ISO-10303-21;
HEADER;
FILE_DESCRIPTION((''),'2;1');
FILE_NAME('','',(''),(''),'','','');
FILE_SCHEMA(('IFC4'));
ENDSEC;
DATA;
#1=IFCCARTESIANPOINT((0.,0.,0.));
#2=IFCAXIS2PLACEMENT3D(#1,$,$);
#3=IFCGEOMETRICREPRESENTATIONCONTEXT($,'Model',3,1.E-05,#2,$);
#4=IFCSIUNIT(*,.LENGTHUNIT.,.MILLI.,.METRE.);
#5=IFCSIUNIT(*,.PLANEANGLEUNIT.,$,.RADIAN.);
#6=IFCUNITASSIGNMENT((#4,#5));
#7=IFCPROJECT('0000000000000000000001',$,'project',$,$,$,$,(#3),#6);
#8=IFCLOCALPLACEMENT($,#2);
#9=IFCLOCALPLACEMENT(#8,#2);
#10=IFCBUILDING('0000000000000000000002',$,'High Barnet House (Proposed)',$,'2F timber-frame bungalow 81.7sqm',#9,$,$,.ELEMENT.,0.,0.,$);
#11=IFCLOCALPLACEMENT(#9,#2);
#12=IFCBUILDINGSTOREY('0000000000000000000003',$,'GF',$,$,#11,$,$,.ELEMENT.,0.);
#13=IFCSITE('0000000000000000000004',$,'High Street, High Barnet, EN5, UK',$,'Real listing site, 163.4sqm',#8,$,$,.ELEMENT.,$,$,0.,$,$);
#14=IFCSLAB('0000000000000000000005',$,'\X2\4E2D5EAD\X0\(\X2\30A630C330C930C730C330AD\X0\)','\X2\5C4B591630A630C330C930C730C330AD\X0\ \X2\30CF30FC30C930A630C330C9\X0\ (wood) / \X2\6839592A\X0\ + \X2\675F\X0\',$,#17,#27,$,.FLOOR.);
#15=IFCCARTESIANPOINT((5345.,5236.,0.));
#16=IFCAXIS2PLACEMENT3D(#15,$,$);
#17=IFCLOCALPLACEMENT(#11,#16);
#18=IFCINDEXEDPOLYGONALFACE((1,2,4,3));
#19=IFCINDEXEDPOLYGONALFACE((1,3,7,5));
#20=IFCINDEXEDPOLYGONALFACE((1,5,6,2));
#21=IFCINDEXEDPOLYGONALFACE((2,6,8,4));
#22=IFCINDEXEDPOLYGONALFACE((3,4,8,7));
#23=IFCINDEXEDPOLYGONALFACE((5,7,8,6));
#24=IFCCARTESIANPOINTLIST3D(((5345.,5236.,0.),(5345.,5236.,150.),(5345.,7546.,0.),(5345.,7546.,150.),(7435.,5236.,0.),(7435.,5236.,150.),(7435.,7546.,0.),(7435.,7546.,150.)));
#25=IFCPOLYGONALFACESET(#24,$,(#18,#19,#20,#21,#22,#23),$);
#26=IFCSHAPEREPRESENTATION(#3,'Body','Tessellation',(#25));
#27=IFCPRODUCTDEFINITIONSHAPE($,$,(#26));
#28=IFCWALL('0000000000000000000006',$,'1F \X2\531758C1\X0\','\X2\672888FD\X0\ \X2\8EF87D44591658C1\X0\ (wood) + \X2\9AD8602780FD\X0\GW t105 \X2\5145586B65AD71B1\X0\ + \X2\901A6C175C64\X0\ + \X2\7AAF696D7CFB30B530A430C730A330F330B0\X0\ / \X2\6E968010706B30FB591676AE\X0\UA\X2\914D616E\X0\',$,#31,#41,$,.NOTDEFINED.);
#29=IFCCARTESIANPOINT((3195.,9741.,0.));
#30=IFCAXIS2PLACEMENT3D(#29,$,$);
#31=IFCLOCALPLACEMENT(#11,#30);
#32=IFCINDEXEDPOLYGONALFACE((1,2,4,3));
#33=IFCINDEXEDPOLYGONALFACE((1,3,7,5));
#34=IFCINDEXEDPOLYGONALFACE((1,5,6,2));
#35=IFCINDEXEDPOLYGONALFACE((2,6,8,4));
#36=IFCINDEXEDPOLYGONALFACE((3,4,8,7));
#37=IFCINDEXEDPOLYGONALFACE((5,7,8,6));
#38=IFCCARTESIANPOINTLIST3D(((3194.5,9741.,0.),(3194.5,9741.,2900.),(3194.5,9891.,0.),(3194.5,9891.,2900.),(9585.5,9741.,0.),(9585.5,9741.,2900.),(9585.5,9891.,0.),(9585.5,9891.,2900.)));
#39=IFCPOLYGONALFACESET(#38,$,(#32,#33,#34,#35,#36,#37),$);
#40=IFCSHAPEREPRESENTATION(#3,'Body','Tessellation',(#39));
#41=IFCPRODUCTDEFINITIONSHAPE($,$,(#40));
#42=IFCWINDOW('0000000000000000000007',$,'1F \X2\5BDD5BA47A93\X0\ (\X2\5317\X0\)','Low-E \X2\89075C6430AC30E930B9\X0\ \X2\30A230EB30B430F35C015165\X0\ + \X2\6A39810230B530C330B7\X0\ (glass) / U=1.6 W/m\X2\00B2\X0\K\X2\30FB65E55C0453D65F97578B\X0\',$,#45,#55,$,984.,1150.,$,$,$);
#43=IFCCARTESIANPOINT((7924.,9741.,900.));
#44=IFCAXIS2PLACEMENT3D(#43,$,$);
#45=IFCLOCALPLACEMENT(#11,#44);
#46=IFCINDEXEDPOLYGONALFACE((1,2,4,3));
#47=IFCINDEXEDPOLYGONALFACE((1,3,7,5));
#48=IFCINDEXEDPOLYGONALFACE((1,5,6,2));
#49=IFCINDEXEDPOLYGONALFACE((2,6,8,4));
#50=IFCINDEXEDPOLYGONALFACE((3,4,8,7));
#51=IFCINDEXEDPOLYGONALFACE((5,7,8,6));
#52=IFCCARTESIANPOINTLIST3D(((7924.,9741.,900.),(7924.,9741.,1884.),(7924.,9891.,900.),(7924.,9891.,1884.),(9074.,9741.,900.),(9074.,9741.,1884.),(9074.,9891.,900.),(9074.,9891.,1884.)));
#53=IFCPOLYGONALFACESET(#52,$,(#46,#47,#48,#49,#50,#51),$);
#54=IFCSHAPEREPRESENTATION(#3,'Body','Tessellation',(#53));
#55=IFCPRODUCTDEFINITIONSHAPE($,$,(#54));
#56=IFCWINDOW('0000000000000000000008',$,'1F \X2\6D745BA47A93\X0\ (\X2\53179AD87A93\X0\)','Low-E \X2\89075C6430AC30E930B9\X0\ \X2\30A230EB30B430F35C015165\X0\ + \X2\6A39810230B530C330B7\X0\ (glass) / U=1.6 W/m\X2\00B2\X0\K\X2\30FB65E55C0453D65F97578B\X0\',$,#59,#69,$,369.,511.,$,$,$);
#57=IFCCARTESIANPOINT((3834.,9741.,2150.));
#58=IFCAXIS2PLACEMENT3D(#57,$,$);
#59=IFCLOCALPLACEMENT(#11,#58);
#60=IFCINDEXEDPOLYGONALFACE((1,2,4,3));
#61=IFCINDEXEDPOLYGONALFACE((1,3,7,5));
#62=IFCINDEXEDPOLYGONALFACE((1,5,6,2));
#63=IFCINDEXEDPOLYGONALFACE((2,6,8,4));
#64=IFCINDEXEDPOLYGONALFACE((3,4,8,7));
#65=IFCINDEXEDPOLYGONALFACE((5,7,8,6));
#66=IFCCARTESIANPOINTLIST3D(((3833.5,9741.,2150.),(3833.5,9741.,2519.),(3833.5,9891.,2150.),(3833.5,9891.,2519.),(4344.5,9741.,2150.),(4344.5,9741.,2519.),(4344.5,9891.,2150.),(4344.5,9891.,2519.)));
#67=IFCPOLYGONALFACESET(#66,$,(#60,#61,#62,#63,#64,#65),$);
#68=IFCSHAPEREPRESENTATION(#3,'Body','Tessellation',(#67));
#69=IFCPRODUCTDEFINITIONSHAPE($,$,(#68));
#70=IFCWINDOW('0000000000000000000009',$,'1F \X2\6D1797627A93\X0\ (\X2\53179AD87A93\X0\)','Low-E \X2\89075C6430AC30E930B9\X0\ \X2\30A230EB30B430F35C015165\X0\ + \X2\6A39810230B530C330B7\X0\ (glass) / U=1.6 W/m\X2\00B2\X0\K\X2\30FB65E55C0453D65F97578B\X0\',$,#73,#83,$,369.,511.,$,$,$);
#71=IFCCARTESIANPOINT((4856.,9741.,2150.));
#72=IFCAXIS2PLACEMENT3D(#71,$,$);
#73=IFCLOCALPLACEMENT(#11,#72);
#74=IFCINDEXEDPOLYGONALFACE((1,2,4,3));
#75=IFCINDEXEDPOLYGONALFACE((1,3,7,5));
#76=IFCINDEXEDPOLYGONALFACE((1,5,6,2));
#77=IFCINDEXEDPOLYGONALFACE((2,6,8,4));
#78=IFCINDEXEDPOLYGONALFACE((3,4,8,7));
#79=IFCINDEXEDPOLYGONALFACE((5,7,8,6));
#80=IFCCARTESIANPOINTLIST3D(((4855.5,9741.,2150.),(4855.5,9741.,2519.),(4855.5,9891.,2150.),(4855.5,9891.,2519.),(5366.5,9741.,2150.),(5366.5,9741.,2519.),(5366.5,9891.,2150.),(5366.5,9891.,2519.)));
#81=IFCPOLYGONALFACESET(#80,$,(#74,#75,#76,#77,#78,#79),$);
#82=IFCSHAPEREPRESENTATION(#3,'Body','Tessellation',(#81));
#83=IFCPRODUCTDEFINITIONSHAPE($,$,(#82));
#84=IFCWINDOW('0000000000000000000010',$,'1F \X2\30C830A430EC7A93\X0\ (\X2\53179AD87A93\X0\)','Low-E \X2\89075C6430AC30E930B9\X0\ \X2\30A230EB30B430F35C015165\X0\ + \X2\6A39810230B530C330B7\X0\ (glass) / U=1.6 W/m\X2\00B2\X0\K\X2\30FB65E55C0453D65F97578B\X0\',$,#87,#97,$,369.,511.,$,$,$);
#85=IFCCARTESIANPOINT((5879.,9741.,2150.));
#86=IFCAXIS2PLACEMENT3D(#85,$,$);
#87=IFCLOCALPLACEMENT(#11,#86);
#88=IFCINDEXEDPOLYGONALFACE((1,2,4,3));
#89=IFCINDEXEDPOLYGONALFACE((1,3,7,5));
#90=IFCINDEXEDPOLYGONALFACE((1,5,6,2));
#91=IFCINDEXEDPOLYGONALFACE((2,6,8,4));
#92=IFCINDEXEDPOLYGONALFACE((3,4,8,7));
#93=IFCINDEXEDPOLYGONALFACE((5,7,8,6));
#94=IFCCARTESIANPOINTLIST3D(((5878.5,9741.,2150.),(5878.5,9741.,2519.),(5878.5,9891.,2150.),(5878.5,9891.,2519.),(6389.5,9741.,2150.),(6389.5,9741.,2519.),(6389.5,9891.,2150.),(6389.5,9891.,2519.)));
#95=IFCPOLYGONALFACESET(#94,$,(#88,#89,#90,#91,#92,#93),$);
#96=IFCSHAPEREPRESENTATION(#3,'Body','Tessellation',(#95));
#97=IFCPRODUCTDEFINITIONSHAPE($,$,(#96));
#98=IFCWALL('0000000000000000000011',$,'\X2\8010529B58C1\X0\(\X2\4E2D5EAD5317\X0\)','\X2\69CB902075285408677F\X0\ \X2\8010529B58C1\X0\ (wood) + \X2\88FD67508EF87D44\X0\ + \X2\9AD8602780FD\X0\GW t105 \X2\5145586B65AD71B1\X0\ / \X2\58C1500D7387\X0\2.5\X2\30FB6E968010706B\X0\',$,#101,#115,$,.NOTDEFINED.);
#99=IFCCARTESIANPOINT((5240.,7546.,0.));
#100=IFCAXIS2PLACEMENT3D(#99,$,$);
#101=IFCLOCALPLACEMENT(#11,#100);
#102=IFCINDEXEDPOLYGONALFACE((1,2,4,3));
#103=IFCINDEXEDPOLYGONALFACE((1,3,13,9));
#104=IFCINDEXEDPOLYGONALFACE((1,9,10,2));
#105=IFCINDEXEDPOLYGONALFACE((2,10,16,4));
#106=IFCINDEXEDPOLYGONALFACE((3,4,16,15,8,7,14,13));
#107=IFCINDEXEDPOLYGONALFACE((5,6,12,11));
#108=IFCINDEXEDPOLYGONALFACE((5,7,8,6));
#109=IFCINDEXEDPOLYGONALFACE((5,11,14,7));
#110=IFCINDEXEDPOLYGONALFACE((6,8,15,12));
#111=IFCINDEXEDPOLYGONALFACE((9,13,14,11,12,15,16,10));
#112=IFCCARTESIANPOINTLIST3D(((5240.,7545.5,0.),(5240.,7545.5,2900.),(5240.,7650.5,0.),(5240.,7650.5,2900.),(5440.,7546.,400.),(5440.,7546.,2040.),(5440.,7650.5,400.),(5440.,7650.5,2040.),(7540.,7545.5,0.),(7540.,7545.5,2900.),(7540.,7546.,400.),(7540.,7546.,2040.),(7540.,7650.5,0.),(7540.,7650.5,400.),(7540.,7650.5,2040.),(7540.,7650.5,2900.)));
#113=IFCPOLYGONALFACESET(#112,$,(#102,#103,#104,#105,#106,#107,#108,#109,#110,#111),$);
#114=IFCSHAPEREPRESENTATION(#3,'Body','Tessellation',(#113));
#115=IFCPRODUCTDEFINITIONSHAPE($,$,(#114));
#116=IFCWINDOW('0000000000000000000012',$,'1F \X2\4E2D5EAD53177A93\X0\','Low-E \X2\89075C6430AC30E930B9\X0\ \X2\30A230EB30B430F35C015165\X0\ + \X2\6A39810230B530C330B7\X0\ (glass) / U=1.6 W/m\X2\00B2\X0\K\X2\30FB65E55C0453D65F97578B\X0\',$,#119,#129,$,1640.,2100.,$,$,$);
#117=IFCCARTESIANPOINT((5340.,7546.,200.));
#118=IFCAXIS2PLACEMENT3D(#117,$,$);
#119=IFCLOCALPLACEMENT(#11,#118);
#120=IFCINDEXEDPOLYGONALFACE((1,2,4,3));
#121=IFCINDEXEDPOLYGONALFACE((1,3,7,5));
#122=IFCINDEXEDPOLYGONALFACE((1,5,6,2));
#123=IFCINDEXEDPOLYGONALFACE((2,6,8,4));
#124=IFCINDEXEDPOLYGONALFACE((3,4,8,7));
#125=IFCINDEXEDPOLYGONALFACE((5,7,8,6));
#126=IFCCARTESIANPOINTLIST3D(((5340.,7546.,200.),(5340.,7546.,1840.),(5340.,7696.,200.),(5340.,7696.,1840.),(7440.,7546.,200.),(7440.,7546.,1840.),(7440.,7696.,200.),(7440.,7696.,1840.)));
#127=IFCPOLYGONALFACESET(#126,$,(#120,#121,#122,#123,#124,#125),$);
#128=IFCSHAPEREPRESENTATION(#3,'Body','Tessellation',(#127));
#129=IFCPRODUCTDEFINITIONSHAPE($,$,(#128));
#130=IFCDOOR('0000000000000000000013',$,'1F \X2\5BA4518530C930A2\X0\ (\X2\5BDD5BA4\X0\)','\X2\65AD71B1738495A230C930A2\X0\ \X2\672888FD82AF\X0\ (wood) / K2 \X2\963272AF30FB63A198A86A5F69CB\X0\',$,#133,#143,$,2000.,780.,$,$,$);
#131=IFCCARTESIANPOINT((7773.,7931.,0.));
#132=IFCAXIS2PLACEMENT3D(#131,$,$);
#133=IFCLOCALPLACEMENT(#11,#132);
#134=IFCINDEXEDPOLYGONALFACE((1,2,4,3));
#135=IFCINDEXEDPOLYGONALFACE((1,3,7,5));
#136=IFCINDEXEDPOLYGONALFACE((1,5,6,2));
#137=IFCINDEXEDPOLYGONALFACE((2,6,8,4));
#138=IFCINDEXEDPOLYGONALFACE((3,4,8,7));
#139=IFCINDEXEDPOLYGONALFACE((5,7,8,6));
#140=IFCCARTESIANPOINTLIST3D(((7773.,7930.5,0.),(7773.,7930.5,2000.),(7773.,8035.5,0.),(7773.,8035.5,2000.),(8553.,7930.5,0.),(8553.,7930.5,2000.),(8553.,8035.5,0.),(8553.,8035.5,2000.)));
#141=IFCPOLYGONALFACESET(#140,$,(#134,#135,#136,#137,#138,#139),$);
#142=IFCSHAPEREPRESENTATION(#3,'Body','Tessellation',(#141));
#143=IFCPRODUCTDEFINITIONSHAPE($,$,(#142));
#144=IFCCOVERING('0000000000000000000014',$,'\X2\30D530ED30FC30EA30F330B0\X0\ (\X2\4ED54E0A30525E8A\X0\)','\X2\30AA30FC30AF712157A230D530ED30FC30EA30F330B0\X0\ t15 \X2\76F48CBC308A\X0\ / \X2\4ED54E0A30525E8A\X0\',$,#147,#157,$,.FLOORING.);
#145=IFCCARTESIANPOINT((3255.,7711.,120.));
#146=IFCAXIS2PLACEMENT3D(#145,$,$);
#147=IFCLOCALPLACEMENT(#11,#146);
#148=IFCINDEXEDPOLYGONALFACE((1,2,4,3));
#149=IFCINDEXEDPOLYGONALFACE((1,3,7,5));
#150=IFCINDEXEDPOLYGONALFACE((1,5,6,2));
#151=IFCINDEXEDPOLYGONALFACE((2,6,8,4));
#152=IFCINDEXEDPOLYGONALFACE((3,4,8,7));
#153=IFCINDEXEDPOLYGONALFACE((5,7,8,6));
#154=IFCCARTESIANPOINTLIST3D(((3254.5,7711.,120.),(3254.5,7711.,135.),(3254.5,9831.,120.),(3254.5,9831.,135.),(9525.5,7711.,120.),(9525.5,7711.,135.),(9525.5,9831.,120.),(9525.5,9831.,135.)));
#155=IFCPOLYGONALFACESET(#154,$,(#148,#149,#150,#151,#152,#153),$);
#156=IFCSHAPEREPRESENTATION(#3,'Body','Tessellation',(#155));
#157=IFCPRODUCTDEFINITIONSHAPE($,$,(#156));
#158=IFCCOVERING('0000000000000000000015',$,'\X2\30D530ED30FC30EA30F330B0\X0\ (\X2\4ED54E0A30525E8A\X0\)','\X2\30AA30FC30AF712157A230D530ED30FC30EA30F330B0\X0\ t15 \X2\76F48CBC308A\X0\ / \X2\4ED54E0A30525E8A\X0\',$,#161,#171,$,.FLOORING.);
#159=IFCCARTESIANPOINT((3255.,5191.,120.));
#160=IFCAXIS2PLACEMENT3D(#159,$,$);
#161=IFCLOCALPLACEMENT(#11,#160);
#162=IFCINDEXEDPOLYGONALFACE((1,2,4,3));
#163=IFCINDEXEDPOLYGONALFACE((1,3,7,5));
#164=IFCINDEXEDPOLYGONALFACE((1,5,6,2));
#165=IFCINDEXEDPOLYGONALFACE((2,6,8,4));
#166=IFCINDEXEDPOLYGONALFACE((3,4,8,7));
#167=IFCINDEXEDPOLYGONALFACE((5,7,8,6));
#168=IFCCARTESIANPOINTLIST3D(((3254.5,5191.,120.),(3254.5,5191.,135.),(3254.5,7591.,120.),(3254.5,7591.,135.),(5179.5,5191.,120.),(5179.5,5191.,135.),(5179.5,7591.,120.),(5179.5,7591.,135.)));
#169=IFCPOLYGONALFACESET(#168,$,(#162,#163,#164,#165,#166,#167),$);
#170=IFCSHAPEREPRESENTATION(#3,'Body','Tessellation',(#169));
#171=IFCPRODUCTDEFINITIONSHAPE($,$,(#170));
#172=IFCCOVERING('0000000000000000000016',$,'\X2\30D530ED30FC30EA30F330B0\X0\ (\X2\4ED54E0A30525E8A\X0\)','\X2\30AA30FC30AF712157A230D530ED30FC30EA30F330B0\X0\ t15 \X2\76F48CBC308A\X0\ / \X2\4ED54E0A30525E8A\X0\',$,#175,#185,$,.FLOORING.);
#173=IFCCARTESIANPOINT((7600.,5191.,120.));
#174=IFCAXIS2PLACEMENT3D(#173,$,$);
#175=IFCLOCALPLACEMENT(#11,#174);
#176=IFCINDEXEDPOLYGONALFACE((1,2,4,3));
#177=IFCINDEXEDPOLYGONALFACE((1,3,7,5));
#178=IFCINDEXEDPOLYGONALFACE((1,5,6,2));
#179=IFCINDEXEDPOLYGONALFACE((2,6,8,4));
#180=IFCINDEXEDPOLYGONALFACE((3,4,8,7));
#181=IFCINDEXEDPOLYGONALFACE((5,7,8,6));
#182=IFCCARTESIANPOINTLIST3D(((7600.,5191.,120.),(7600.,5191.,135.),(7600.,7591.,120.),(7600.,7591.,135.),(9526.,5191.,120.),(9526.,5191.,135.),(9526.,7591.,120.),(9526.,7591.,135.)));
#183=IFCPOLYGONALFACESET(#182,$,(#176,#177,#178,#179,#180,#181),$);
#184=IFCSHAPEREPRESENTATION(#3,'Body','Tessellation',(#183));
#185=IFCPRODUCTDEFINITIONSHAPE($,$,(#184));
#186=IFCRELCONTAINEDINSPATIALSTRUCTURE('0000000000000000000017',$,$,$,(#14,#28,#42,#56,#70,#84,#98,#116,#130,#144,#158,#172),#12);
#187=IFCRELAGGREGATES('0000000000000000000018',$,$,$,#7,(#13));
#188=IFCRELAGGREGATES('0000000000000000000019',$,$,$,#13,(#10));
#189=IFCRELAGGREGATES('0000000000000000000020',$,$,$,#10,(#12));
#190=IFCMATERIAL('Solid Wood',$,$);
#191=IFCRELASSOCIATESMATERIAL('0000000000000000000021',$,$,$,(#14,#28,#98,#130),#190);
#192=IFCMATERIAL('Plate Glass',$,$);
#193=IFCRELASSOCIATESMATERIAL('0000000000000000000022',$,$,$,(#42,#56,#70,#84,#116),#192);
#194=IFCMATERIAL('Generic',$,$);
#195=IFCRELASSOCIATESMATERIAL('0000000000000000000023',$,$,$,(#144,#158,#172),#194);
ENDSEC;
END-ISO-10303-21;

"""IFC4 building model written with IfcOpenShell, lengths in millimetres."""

from ifc_helpers import new_model, si_unit, frame, frame_2d, origin, place, context, project, spatial, rectangle, extrude, material, element, fill, save


model = new_model("IFC4")

# Units and contexts
model_context = context("Model", 3, precision=1e-05, world=origin())
ifc_project = project(units=[si_unit("LENGTHUNIT", "METRE", prefix="MILLI"), si_unit("PLANEANGLEUNIT", "RADIAN")], contexts=[model_context])

# Site, building, storey
site_placement = place(None, origin())
site = spatial("IfcSite", under=ifc_project, at=site_placement, Name="High Street, High Barnet, EN5, UK", ObjectType="Real listing site, 163.4sqm", CompositionType="ELEMENT", RefElevation=0.0)
building_placement = place(site_placement, origin())
building = spatial("IfcBuilding", under=site, at=building_placement, Name="High Barnet House (Proposed)", ObjectType="2F timber-frame bungalow 81.7sqm", CompositionType="ELEMENT", ElevationOfRefHeight=0.0, ElevationOfTerrain=0.0)
storey_placement = place(building_placement, origin())
storey = spatial("IfcBuildingStorey", under=building, at=storey_placement, Name="GF", CompositionType="ELEMENT", Elevation=0.0)

# Slab
ifc_material_1 = material(Name="Solid Wood")
slab_1_placement = place(storey_placement, frame((5345.0, 5236.0, 0.0)))
element("IfcSlab", 1, at=slab_1_placement, inside=storey, material=ifc_material_1, Name="中庭(ウッドデッキ)", Description="屋外ウッドデッキ ハードウッド (wood) / 根太 + 束", PredefinedType="FLOOR", context=model_context, shape_type="SweptSolid", body=[
    extrude(rectangle(XDim=2090.0, YDim=2310.0, at=frame_2d((1045.0, 1155.0))), frame((5345.0, 5236.0, 0.0)), (0.0, 0.0, 1.0), 150.0),
])

# Wall, openings, windows
wall_1_placement = place(storey_placement, frame((3195.0, 9741.0, 0.0)))
wall_1 = element("IfcWall", 2, at=wall_1_placement, inside=storey, material=ifc_material_1, Name="1F 北壁", Description="木製 軸組外壁 (wood) + 高性能GW t105 充填断熱 + 通気層 + 窯業系サイディング / 準耐火・外皮UA配慮", PredefinedType="NOTDEFINED", context=model_context, shape_type="SweptSolid", body=[
    extrude(rectangle(XDim=6391.0, YDim=150.0, at=frame_2d((3195.0, 75.0))), frame((3195.0, 9741.0, 0.0)), (0.0, 0.0, 1.0), 2900.0),
])
opening_1_placement = place(storey_placement, frame((7924.0, 9741.0, 900.0)))
opening_1 = element("IfcOpeningElement", 3, at=opening_1_placement, cuts=wall_1, PredefinedType="NOTDEFINED", context=model_context, shape_type="SweptSolid", body=[
    extrude(rectangle(XDim=1150.0, YDim=150.0, at=frame_2d((575.0, 75.0))), frame((7924.0, 9741.0, 900.0)), (0.0, 0.0, 1.0), 984.0),
])
opening_2_placement = place(storey_placement, frame((3834.0, 9741.0, 2150.0)))
opening_2 = element("IfcOpeningElement", 4, at=opening_2_placement, cuts=wall_1, PredefinedType="NOTDEFINED", context=model_context, shape_type="SweptSolid", body=[
    extrude(rectangle(XDim=511.0, YDim=150.0, at=frame_2d((255.0, 75.0))), frame((3834.0, 9741.0, 2150.0)), (0.0, 0.0, 1.0), 369.0),
])
opening_3_placement = place(storey_placement, frame((4856.0, 9741.0, 2150.0)))
opening_3 = element("IfcOpeningElement", 5, at=opening_3_placement, cuts=wall_1, PredefinedType="NOTDEFINED", context=model_context, shape_type="SweptSolid", body=[
    extrude(rectangle(XDim=511.0, YDim=150.0, at=frame_2d((255.0, 75.0))), frame((4856.0, 9741.0, 2150.0)), (0.0, 0.0, 1.0), 369.0),
])
opening_4_placement = place(storey_placement, frame((5879.0, 9741.0, 2150.0)))
opening_4 = element("IfcOpeningElement", 6, at=opening_4_placement, cuts=wall_1, PredefinedType="NOTDEFINED", context=model_context, shape_type="SweptSolid", body=[
    extrude(rectangle(XDim=511.0, YDim=150.0, at=frame_2d((255.0, 75.0))), frame((5879.0, 9741.0, 2150.0)), (0.0, 0.0, 1.0), 369.0),
])
ifc_material_2 = material(Name="Plate Glass")
window_1_placement = place(storey_placement, frame((7924.0, 9741.0, 900.0)))
window_1 = element("IfcWindow", 7, at=window_1_placement, inside=storey, material=ifc_material_2, Name="1F 寝室窓 (北)", Description="Low-E 複層ガラス アルゴン封入 + 樹脂サッシ (glass) / U=1.6 W/m²K・日射取得型", OverallHeight=984.0, OverallWidth=1150.0, context=model_context, shape_type="SweptSolid", body=[
    extrude(rectangle(XDim=1150.0, YDim=150.0, at=frame_2d((575.0, 75.0))), frame((7924.0, 9741.0, 900.0)), (0.0, 0.0, 1.0), 984.0),
])
fill(opening_1, window_1)
window_2_placement = place(storey_placement, frame((3834.0, 9741.0, 2150.0)))
window_2 = element("IfcWindow", 8, at=window_2_placement, inside=storey, material=ifc_material_2, Name="1F 浴室窓 (北高窓)", Description="Low-E 複層ガラス アルゴン封入 + 樹脂サッシ (glass) / U=1.6 W/m²K・日射取得型", OverallHeight=369.0, OverallWidth=511.0, context=model_context, shape_type="SweptSolid", body=[
    extrude(rectangle(XDim=511.0, YDim=150.0, at=frame_2d((255.0, 75.0))), frame((3834.0, 9741.0, 2150.0)), (0.0, 0.0, 1.0), 369.0),
])
fill(opening_2, window_2)
window_3_placement = place(storey_placement, frame((4856.0, 9741.0, 2150.0)))
window_3 = element("IfcWindow", 9, at=window_3_placement, inside=storey, material=ifc_material_2, Name="1F 洗面窓 (北高窓)", Description="Low-E 複層ガラス アルゴン封入 + 樹脂サッシ (glass) / U=1.6 W/m²K・日射取得型", OverallHeight=369.0, OverallWidth=511.0, context=model_context, shape_type="SweptSolid", body=[
    extrude(rectangle(XDim=511.0, YDim=150.0, at=frame_2d((255.0, 75.0))), frame((4856.0, 9741.0, 2150.0)), (0.0, 0.0, 1.0), 369.0),
])
fill(opening_3, window_3)
window_4_placement = place(storey_placement, frame((5879.0, 9741.0, 2150.0)))
window_4 = element("IfcWindow", 10, at=window_4_placement, inside=storey, material=ifc_material_2, Name="1F トイレ窓 (北高窓)", Description="Low-E 複層ガラス アルゴン封入 + 樹脂サッシ (glass) / U=1.6 W/m²K・日射取得型", OverallHeight=369.0, OverallWidth=511.0, context=model_context, shape_type="SweptSolid", body=[
    extrude(rectangle(XDim=511.0, YDim=150.0, at=frame_2d((255.0, 75.0))), frame((5879.0, 9741.0, 2150.0)), (0.0, 0.0, 1.0), 369.0),
])
fill(opening_4, window_4)

# Wall, opening, window
wall_2_placement = place(storey_placement, frame((5240.0, 7546.0, 0.0)))
wall_2 = element("IfcWall", 11, at=wall_2_placement, inside=storey, material=ifc_material_1, Name="耐力壁(中庭北)", Description="構造用合板 耐力壁 (wood) + 製材軸組 + 高性能GW t105 充填断熱 / 壁倍率2.5・準耐火", PredefinedType="NOTDEFINED", context=model_context, shape_type="SweptSolid", body=[
    extrude(rectangle(XDim=2300.0, YDim=105.0, at=frame_2d((1150.0, 52.0))), frame((5240.0, 7546.0, 0.0)), (0.0, 0.0, 1.0), 2900.0),
])
opening_5_placement = place(storey_placement, frame((5340.0, 7546.0, 200.0)))
opening_5 = element("IfcOpeningElement", 12, at=opening_5_placement, cuts=wall_2, PredefinedType="NOTDEFINED", context=model_context, shape_type="SweptSolid", body=[
    extrude(rectangle(XDim=2100.0, YDim=150.0, at=frame_2d((1050.0, 75.0))), frame((5340.0, 7546.0, 200.0)), (0.0, 0.0, 1.0), 1640.0),
])
window_5_placement = place(storey_placement, frame((5340.0, 7546.0, 200.0)))
window_5 = element("IfcWindow", 13, at=window_5_placement, inside=storey, material=ifc_material_2, Name="1F 中庭北窓", Description="Low-E 複層ガラス アルゴン封入 + 樹脂サッシ (glass) / U=1.6 W/m²K・日射取得型", OverallHeight=1640.0, OverallWidth=2100.0, context=model_context, shape_type="SweptSolid", body=[
    extrude(rectangle(XDim=2100.0, YDim=150.0, at=frame_2d((1050.0, 75.0))), frame((5340.0, 7546.0, 200.0)), (0.0, 0.0, 1.0), 1640.0),
])
fill(opening_5, window_5)

# Door
door_1_placement = place(storey_placement, frame((7773.0, 7931.0, 0.0)))
element("IfcDoor", 14, at=door_1_placement, inside=storey, material=ifc_material_1, Name="1F 室内ドア (寝室)", Description="断熱玄関ドア 木製芯 (wood) / K2 防犯・採風機構", OverallHeight=2000.0, OverallWidth=780.0, context=model_context, shape_type="SweptSolid", body=[
    extrude(rectangle(XDim=780.0, YDim=105.0, at=frame_2d((390.0, 52.0))), frame((7773.0, 7931.0, 0.0)), (0.0, 0.0, 1.0), 2000.0),
])

# Coverings
ifc_material_3 = material(Name="Generic")
covering_1_placement = place(storey_placement, frame((3255.0, 7711.0, 120.0)))
element("IfcCovering", 15, at=covering_1_placement, inside=storey, material=ifc_material_3, Name="フローリング (仕上げ床)", Description="オーク無垢フローリング t15 直貼り / 仕上げ床", PredefinedType="FLOORING", context=model_context, shape_type="SweptSolid", body=[
    extrude(rectangle(XDim=6271.0, YDim=2120.0, at=frame_2d((3135.0, 1060.0))), frame((3255.0, 7711.0, 120.0)), (0.0, 0.0, 1.0), 15.0),
])
covering_2_placement = place(storey_placement, frame((3255.0, 5191.0, 120.0)))
element("IfcCovering", 16, at=covering_2_placement, inside=storey, material=ifc_material_3, Name="フローリング (仕上げ床)", Description="オーク無垢フローリング t15 直貼り / 仕上げ床", PredefinedType="FLOORING", context=model_context, shape_type="SweptSolid", body=[
    extrude(rectangle(XDim=1925.0, YDim=2400.0, at=frame_2d((962.0, 1200.0))), frame((3255.0, 5191.0, 120.0)), (0.0, 0.0, 1.0), 15.0),
])
covering_3_placement = place(storey_placement, frame((7600.0, 5191.0, 120.0)))
element("IfcCovering", 17, at=covering_3_placement, inside=storey, material=ifc_material_3, Name="フローリング (仕上げ床)", Description="オーク無垢フローリング t15 直貼り / 仕上げ床", PredefinedType="FLOORING", context=model_context, shape_type="SweptSolid", body=[
    extrude(rectangle(XDim=1926.0, YDim=2400.0, at=frame_2d((963.0, 1200.0))), frame((7600.0, 5191.0, 120.0)), (0.0, 0.0, 1.0), 15.0),
])

save(model, "model.ifc")
